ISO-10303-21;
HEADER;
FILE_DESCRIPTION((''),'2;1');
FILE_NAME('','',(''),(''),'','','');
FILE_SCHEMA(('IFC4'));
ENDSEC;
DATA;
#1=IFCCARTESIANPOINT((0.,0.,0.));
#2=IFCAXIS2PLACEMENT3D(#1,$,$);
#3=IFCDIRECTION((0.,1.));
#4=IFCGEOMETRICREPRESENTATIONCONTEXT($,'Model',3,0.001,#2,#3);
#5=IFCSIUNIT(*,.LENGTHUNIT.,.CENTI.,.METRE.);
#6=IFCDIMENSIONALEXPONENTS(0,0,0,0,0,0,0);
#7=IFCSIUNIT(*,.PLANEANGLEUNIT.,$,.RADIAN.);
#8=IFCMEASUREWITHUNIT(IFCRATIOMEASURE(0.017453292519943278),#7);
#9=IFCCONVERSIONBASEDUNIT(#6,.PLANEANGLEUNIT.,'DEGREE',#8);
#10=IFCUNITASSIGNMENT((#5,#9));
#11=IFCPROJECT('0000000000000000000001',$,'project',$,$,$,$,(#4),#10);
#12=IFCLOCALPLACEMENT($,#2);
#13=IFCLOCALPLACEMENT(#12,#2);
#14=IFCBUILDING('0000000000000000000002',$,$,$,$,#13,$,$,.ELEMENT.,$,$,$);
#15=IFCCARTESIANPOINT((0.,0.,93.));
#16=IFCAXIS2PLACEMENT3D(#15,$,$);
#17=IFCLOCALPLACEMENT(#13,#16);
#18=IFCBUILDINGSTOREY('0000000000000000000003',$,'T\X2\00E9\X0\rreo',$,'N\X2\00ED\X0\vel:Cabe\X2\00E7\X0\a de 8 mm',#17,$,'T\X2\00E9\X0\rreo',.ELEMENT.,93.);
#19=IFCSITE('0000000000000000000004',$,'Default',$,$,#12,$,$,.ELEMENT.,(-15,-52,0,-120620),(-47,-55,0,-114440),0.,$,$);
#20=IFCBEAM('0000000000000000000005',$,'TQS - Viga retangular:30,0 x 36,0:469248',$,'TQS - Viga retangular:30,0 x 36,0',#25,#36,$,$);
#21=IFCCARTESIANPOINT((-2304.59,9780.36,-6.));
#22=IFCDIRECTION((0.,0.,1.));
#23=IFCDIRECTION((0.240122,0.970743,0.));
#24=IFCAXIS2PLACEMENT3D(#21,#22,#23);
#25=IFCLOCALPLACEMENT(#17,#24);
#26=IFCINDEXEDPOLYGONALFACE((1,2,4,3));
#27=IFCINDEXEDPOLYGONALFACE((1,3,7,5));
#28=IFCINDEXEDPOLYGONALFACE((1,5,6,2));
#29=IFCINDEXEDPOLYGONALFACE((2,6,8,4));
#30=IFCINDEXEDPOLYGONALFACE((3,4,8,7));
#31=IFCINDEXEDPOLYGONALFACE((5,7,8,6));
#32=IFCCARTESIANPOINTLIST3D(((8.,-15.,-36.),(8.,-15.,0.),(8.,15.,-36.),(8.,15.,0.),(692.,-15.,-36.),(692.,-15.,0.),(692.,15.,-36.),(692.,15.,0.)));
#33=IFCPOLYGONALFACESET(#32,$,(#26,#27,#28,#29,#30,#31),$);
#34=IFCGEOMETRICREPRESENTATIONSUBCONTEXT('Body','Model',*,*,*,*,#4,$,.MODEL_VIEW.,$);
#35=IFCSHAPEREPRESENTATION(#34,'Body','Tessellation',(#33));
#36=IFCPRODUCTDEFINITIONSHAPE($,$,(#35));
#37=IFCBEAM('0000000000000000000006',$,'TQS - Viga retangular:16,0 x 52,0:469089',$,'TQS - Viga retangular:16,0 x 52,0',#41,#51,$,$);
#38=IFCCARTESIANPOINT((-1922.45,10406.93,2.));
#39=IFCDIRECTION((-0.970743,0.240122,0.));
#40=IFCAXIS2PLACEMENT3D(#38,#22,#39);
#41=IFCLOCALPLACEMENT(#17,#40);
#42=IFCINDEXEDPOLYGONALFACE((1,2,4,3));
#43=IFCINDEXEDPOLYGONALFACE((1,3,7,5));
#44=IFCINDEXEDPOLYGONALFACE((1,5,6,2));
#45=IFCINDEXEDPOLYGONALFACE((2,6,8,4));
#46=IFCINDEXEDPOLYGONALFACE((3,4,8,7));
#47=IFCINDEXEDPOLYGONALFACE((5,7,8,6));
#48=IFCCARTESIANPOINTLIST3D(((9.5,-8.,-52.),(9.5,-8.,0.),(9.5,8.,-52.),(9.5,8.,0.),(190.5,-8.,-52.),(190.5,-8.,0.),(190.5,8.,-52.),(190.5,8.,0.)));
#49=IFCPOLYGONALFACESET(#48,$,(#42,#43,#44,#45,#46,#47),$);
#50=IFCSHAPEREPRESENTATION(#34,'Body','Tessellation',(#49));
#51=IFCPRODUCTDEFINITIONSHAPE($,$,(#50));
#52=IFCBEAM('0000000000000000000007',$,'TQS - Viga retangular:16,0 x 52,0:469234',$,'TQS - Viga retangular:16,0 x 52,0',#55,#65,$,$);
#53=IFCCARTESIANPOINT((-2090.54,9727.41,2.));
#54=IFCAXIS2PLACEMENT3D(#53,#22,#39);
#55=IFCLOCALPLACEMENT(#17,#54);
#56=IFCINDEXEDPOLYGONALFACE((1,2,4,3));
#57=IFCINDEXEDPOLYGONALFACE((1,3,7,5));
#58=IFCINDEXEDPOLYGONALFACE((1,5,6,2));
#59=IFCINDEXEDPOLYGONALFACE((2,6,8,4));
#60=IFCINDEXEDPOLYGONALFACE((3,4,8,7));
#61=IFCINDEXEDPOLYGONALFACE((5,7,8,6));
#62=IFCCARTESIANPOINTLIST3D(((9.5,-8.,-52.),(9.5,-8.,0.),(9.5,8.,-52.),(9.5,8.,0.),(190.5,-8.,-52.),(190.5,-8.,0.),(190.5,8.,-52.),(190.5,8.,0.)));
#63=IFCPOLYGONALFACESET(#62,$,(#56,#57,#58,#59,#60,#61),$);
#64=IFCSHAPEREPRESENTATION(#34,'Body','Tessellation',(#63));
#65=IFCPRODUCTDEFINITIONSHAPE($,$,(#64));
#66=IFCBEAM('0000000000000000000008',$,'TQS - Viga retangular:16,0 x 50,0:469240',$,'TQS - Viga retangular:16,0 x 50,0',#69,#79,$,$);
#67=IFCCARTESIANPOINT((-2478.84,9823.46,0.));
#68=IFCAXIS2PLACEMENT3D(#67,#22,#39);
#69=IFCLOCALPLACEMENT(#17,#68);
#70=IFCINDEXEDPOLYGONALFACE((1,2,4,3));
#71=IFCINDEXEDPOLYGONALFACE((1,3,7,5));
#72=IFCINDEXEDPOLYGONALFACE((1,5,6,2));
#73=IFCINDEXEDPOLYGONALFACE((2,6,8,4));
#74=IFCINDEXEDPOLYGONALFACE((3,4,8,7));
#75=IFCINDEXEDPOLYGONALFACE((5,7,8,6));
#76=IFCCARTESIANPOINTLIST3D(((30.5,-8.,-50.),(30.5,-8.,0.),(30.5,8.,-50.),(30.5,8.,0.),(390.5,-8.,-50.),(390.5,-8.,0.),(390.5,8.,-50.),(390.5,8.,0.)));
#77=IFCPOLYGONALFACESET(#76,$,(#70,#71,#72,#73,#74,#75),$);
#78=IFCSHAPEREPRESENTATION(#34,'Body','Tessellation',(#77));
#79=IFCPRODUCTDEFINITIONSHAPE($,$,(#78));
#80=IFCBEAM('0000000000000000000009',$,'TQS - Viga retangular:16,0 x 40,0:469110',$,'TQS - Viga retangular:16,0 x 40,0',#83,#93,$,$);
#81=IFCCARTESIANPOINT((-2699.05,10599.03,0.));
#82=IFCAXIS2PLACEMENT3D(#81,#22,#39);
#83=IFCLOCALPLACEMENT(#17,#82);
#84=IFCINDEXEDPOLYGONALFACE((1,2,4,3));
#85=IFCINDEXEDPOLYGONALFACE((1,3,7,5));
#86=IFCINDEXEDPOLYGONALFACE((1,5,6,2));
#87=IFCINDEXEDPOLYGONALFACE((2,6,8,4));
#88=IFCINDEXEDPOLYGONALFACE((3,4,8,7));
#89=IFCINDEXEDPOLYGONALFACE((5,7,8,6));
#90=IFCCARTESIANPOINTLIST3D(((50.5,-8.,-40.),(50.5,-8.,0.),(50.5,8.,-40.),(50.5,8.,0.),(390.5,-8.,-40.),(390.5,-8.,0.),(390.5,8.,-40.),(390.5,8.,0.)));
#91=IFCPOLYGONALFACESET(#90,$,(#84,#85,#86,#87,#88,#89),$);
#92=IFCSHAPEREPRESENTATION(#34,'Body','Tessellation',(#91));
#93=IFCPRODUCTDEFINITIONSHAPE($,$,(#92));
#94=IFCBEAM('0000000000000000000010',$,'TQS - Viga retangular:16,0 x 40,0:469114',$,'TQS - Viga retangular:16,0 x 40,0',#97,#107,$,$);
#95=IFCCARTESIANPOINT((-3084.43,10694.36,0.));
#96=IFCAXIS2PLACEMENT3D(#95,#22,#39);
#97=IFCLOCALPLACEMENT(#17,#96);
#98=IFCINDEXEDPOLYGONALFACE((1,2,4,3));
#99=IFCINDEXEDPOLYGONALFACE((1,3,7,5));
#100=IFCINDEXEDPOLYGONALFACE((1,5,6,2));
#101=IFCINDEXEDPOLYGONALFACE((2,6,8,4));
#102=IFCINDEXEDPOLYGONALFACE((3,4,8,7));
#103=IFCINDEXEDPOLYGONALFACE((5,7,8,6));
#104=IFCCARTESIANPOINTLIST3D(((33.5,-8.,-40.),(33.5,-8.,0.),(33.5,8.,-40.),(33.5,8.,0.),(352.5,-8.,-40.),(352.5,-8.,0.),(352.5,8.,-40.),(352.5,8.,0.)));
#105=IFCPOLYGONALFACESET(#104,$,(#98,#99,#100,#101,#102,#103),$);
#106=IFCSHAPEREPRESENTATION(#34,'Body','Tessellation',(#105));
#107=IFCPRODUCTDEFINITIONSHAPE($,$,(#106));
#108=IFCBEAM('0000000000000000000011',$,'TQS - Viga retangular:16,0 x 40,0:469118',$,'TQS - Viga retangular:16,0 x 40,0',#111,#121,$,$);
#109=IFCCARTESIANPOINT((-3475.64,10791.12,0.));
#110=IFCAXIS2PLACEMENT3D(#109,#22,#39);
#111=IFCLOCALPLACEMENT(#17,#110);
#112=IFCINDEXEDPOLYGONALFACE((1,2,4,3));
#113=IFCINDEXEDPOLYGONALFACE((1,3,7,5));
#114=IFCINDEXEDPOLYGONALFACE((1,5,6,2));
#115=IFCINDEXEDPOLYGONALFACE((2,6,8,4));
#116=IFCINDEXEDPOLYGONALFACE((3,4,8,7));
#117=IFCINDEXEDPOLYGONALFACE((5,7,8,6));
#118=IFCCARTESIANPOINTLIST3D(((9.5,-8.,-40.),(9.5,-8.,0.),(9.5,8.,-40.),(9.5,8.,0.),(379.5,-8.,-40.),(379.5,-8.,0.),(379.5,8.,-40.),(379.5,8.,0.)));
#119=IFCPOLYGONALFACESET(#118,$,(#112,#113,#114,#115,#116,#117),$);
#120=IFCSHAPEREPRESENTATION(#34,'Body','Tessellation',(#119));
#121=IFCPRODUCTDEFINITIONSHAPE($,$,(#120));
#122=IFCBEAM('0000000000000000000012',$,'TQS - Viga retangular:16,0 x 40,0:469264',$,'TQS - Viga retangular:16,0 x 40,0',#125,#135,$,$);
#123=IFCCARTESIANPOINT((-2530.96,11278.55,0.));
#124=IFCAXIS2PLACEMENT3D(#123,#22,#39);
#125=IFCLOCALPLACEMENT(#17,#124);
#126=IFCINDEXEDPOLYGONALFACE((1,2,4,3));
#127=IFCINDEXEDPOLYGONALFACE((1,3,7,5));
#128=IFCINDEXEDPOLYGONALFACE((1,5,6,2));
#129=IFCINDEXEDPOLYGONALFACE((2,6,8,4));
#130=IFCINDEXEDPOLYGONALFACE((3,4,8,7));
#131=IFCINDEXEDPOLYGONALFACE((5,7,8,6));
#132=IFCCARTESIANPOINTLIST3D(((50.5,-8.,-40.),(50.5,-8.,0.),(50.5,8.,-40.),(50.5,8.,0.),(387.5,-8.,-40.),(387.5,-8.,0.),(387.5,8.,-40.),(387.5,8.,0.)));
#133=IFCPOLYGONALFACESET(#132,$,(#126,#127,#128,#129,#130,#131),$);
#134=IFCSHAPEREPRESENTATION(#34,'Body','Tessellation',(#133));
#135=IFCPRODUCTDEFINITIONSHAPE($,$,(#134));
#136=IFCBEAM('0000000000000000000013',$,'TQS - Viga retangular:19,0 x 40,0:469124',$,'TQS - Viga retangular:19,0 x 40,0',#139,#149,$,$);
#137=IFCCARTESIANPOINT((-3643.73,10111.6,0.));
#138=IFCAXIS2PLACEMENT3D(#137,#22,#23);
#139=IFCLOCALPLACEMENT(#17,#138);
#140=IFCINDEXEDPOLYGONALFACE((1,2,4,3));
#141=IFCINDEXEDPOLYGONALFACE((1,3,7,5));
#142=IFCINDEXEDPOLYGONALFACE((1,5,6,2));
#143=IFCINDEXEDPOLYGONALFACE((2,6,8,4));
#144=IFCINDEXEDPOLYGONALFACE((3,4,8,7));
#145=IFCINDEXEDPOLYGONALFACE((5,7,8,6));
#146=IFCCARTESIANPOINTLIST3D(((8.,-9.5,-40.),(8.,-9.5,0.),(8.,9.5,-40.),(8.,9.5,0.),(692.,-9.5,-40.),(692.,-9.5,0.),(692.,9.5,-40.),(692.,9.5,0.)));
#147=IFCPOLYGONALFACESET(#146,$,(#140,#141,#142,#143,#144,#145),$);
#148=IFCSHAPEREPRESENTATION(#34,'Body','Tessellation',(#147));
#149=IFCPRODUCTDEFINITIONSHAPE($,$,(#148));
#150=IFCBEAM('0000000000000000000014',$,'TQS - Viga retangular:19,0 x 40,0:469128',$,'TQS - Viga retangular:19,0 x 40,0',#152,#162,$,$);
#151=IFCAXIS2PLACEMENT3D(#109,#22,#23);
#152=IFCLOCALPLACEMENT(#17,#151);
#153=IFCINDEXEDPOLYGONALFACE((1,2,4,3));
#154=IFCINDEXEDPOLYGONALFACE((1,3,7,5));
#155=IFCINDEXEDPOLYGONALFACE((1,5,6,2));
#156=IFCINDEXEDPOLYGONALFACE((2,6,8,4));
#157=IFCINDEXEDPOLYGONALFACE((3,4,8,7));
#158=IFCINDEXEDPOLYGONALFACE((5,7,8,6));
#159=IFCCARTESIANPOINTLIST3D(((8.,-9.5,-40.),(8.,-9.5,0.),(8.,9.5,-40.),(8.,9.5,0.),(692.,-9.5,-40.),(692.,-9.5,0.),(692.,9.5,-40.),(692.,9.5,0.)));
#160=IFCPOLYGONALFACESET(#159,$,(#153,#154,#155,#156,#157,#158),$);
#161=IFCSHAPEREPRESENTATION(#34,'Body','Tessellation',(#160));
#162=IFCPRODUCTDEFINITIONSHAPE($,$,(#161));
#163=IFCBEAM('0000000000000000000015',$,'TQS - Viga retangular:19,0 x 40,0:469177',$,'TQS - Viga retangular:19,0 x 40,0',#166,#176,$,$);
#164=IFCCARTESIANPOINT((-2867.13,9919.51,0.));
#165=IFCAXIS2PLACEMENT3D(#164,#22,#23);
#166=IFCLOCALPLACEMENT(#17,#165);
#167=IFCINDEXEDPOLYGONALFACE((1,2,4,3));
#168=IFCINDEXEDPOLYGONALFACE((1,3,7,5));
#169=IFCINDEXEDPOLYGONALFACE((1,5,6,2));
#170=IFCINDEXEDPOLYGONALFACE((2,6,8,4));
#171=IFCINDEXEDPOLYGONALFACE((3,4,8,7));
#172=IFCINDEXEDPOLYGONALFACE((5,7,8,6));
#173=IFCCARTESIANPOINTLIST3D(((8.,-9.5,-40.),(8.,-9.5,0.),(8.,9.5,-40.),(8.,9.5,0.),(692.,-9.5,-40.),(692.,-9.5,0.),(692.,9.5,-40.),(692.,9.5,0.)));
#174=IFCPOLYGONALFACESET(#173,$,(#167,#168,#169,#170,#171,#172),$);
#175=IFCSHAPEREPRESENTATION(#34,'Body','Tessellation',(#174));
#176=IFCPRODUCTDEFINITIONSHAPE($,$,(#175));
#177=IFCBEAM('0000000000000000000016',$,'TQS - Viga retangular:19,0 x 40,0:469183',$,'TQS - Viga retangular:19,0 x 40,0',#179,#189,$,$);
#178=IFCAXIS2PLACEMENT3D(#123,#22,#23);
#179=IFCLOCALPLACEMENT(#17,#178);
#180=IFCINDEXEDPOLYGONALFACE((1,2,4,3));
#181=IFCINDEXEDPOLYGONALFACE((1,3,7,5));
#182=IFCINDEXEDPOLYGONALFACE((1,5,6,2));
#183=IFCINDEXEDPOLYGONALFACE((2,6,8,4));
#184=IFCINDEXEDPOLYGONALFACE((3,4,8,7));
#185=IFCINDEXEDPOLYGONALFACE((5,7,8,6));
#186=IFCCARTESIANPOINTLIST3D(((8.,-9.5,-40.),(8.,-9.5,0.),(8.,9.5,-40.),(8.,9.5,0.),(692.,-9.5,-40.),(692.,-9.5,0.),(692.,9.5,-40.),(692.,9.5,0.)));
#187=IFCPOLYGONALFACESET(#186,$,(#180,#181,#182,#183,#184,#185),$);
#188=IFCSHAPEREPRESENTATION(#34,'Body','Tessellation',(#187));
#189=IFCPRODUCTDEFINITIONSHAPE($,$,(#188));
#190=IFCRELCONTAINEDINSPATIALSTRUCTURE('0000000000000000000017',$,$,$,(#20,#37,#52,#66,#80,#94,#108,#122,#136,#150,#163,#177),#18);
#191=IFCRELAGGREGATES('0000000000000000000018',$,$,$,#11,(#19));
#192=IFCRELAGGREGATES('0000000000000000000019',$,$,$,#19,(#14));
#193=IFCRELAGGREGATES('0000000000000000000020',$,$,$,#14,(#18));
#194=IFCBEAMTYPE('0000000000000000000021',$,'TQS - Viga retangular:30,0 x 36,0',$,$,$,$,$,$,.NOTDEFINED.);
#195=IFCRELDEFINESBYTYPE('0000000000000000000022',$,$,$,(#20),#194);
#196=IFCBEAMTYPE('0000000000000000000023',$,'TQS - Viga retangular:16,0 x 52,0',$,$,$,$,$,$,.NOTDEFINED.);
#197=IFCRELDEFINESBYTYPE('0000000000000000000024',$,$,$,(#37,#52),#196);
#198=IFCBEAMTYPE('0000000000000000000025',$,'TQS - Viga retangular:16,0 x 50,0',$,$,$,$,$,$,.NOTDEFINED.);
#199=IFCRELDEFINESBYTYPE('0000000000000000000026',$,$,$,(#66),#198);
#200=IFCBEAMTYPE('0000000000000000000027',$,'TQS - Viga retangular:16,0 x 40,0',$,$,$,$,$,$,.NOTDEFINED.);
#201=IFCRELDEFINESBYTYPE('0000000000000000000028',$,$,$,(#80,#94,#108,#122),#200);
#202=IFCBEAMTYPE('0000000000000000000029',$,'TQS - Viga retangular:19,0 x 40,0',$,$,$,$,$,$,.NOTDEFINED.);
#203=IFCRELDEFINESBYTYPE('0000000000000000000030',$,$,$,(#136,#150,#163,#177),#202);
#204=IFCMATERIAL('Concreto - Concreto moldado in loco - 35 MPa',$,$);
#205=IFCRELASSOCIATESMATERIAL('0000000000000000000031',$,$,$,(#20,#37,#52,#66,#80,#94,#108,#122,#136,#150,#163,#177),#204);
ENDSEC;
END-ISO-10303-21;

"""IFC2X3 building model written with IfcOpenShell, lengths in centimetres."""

from ifc_helpers import new_model, entity, si_unit, converted_unit, direction, frame, frame_2d, origin, place, context, subcontext, project, spatial, rectangle, extrude, material, type_object, element, save


model = new_model("IFC2X3")

# Units and contexts
model_context = context("Model", 3, precision=0.001, world=origin(), true_north=direction((0.0, 1.0)))
body_context = subcontext(model_context, "Body", "Model", "MODEL_VIEW")
ifc_project = project(units=[si_unit("LENGTHUNIT", "METRE", prefix="CENTI"), converted_unit("PLANEANGLEUNIT", "DEGREE", entity("IfcRatioMeasure", 0.017453292519943278), si_unit("PLANEANGLEUNIT", "RADIAN"), dimensions=[0, 0, 0, 0, 0, 0, 0])], contexts=[model_context])

# Site, building, storey
site_placement = place(None, origin())
site = spatial("IfcSite", under=ifc_project, at=site_placement, Name="Default", CompositionType="ELEMENT", RefLatitude=(-15, -52, 0, -120620), RefLongitude=(-47, -55, 0, -114440), RefElevation=0.0)
building_placement = place(site_placement, origin())
building = spatial("IfcBuilding", under=site, at=building_placement, CompositionType="ELEMENT")
storey_placement = place(building_placement, frame((0.0, 0.0, 93.0)))
storey = spatial("IfcBuildingStorey", under=building, at=storey_placement, Name="Térreo", ObjectType="Nível:Cabeça de 8 mm", LongName="Térreo", CompositionType="ELEMENT", Elevation=93.0)

# Beams
ifc_material_1 = material(Name="Concreto - Concreto moldado in loco - 35 MPa")
beam_type_1 = type_object("IfcBeamType", Name="TQS - Viga retangular:30,0 x 36,0", PredefinedType="NOTDEFINED")
beam_1_placement = place(storey_placement, frame((-2304.59, 9780.36, -6.0), z_axis=(0.0, 0.0, 1.0), x_axis=(0.240122, 0.970743, 0.0)))
element("IfcBeam", 1, at=beam_1_placement, inside=storey, type_object=beam_type_1, material=ifc_material_1, Name="TQS - Viga retangular:30,0 x 36,0:469248", ObjectType="TQS - Viga retangular:30,0 x 36,0", context=body_context, shape_type="SweptSolid", body=[
    extrude(rectangle(XDim=36.0, YDim=30.0, at=frame_2d((0.0, 0.0), x_axis=(1.0, 0.0))), frame((8.0, 0.0, -18.0), z_axis=(1.0, 0.0, 0.0), x_axis=(0.0, 0.0, -1.0)), (0.0, 0.0, 1.0), 684.0),
])
beam_type_2 = type_object("IfcBeamType", Name="TQS - Viga retangular:16,0 x 52,0", PredefinedType="NOTDEFINED")
beam_2_placement = place(storey_placement, frame((-1922.45, 10406.93, 2.0), z_axis=(0.0, 0.0, 1.0), x_axis=(-0.970743, 0.240122, 0.0)))
element("IfcBeam", 2, at=beam_2_placement, inside=storey, type_object=beam_type_2, material=ifc_material_1, Name="TQS - Viga retangular:16,0 x 52,0:469089", ObjectType="TQS - Viga retangular:16,0 x 52,0", context=body_context, shape_type="SweptSolid", body=[
    extrude(rectangle(XDim=52.0, YDim=16.0, at=frame_2d((0.0, 0.0), x_axis=(1.0, 0.0))), frame((9.5, 0.0, -26.0), z_axis=(1.0, 0.0, 0.0), x_axis=(0.0, 0.0, -1.0)), (0.0, 0.0, 1.0), 181.0),
])
beam_3_placement = place(storey_placement, frame((-2090.54, 9727.41, 2.0), z_axis=(0.0, 0.0, 1.0), x_axis=(-0.970743, 0.240122, 0.0)))
element("IfcBeam", 3, at=beam_3_placement, inside=storey, type_object=beam_type_2, material=ifc_material_1, Name="TQS - Viga retangular:16,0 x 52,0:469234", ObjectType="TQS - Viga retangular:16,0 x 52,0", context=body_context, shape_type="SweptSolid", body=[
    extrude(rectangle(XDim=52.0, YDim=16.0, at=frame_2d((0.0, 0.0), x_axis=(1.0, 0.0))), frame((9.5, 0.0, -26.0), z_axis=(1.0, 0.0, 0.0), x_axis=(0.0, 0.0, -1.0)), (0.0, 0.0, 1.0), 181.0),
])
beam_type_3 = type_object("IfcBeamType", Name="TQS - Viga retangular:16,0 x 50,0", PredefinedType="NOTDEFINED")
beam_4_placement = place(storey_placement, frame((-2478.84, 9823.46, 0.0), z_axis=(0.0, 0.0, 1.0), x_axis=(-0.970743, 0.240122, 0.0)))
element("IfcBeam", 4, at=beam_4_placement, inside=storey, type_object=beam_type_3, material=ifc_material_1, Name="TQS - Viga retangular:16,0 x 50,0:469240", ObjectType="TQS - Viga retangular:16,0 x 50,0", context=body_context, shape_type="SweptSolid", body=[
    extrude(rectangle(XDim=50.0, YDim=16.0, at=frame_2d((0.0, 0.0), x_axis=(1.0, 0.0))), frame((30.5, 0.0, -25.0), z_axis=(1.0, 0.0, 0.0), x_axis=(0.0, 0.0, -1.0)), (0.0, 0.0, 1.0), 360.0),
])
beam_type_4 = type_object("IfcBeamType", Name="TQS - Viga retangular:16,0 x 40,0", PredefinedType="NOTDEFINED")
beam_5_placement = place(storey_placement, frame((-2699.05, 10599.03, 0.0), z_axis=(0.0, 0.0, 1.0), x_axis=(-0.970743, 0.240122, 0.0)))
element("IfcBeam", 5, at=beam_5_placement, inside=storey, type_object=beam_type_4, material=ifc_material_1, Name="TQS - Viga retangular:16,0 x 40,0:469110", ObjectType="TQS - Viga retangular:16,0 x 40,0", context=body_context, shape_type="SweptSolid", body=[
    extrude(rectangle(XDim=40.0, YDim=16.0, at=frame_2d((0.0, 0.0), x_axis=(1.0, 0.0))), frame((50.5, 0.0, -20.0), z_axis=(1.0, 0.0, 0.0), x_axis=(0.0, 0.0, -1.0)), (0.0, 0.0, 1.0), 340.0),
])
beam_6_placement = place(storey_placement, frame((-3084.43, 10694.36, 0.0), z_axis=(0.0, 0.0, 1.0), x_axis=(-0.970743, 0.240122, 0.0)))
element("IfcBeam", 6, at=beam_6_placement, inside=storey, type_object=beam_type_4, material=ifc_material_1, Name="TQS - Viga retangular:16,0 x 40,0:469114", ObjectType="TQS - Viga retangular:16,0 x 40,0", context=body_context, shape_type="SweptSolid", body=[
    extrude(rectangle(XDim=40.0, YDim=16.0, at=frame_2d((0.0, 0.0), x_axis=(1.0, 0.0))), frame((33.5, 0.0, -20.0), z_axis=(1.0, 0.0, 0.0), x_axis=(0.0, 0.0, -1.0)), (0.0, 0.0, 1.0), 319.0),
])
beam_7_placement = place(storey_placement, frame((-3475.64, 10791.12, 0.0), z_axis=(0.0, 0.0, 1.0), x_axis=(-0.970743, 0.240122, 0.0)))
element("IfcBeam", 7, at=beam_7_placement, inside=storey, type_object=beam_type_4, material=ifc_material_1, Name="TQS - Viga retangular:16,0 x 40,0:469118", ObjectType="TQS - Viga retangular:16,0 x 40,0", context=body_context, shape_type="SweptSolid", body=[
    extrude(rectangle(XDim=40.0, YDim=16.0, at=frame_2d((0.0, 0.0), x_axis=(1.0, 0.0))), frame((9.5, 0.0, -20.0), z_axis=(1.0, 0.0, 0.0), x_axis=(0.0, 0.0, -1.0)), (0.0, 0.0, 1.0), 370.0),
])
beam_8_placement = place(storey_placement, frame((-2530.96, 11278.55, 0.0), z_axis=(0.0, 0.0, 1.0), x_axis=(-0.970743, 0.240122, 0.0)))
element("IfcBeam", 8, at=beam_8_placement, inside=storey, type_object=beam_type_4, material=ifc_material_1, Name="TQS - Viga retangular:16,0 x 40,0:469264", ObjectType="TQS - Viga retangular:16,0 x 40,0", context=body_context, shape_type="SweptSolid", body=[
    extrude(rectangle(XDim=40.0, YDim=16.0, at=frame_2d((0.0, 0.0), x_axis=(1.0, 0.0))), frame((50.5, 0.0, -20.0), z_axis=(1.0, 0.0, 0.0), x_axis=(0.0, 0.0, -1.0)), (0.0, 0.0, 1.0), 337.0),
])
beam_type_5 = type_object("IfcBeamType", Name="TQS - Viga retangular:19,0 x 40,0", PredefinedType="NOTDEFINED")
beam_9_placement = place(storey_placement, frame((-3643.73, 10111.6, 0.0), z_axis=(0.0, 0.0, 1.0), x_axis=(0.240122, 0.970743, 0.0)))
element("IfcBeam", 9, at=beam_9_placement, inside=storey, type_object=beam_type_5, material=ifc_material_1, Name="TQS - Viga retangular:19,0 x 40,0:469124", ObjectType="TQS - Viga retangular:19,0 x 40,0", context=body_context, shape_type="SweptSolid", body=[
    extrude(rectangle(XDim=40.0, YDim=19.0, at=frame_2d((0.0, 0.0), x_axis=(1.0, 0.0))), frame((8.0, 0.0, -20.0), z_axis=(1.0, 0.0, 0.0), x_axis=(0.0, 0.0, -1.0)), (0.0, 0.0, 1.0), 684.0),
])
beam_10_placement = place(storey_placement, frame((-3475.64, 10791.12, 0.0), z_axis=(0.0, 0.0, 1.0), x_axis=(0.240122, 0.970743, 0.0)))
element("IfcBeam", 10, at=beam_10_placement, inside=storey, type_object=beam_type_5, material=ifc_material_1, Name="TQS - Viga retangular:19,0 x 40,0:469128", ObjectType="TQS - Viga retangular:19,0 x 40,0", context=body_context, shape_type="SweptSolid", body=[
    extrude(rectangle(XDim=40.0, YDim=19.0, at=frame_2d((0.0, 0.0), x_axis=(1.0, 0.0))), frame((8.0, 0.0, -20.0), z_axis=(1.0, 0.0, 0.0), x_axis=(0.0, 0.0, -1.0)), (0.0, 0.0, 1.0), 684.0),
])
beam_11_placement = place(storey_placement, frame((-2867.13, 9919.51, 0.0), z_axis=(0.0, 0.0, 1.0), x_axis=(0.240122, 0.970743, 0.0)))
element("IfcBeam", 11, at=beam_11_placement, inside=storey, type_object=beam_type_5, material=ifc_material_1, Name="TQS - Viga retangular:19,0 x 40,0:469177", ObjectType="TQS - Viga retangular:19,0 x 40,0", context=body_context, shape_type="SweptSolid", body=[
    extrude(rectangle(XDim=40.0, YDim=19.0, at=frame_2d((0.0, 0.0), x_axis=(1.0, 0.0))), frame((8.0, 0.0, -20.0), z_axis=(1.0, 0.0, 0.0), x_axis=(0.0, 0.0, -1.0)), (0.0, 0.0, 1.0), 684.0),
])
beam_12_placement = place(storey_placement, frame((-2530.96, 11278.55, 0.0), z_axis=(0.0, 0.0, 1.0), x_axis=(0.240122, 0.970743, 0.0)))
element("IfcBeam", 12, at=beam_12_placement, inside=storey, type_object=beam_type_5, material=ifc_material_1, Name="TQS - Viga retangular:19,0 x 40,0:469183", ObjectType="TQS - Viga retangular:19,0 x 40,0", context=body_context, shape_type="SweptSolid", body=[
    extrude(rectangle(XDim=40.0, YDim=19.0, at=frame_2d((0.0, 0.0), x_axis=(1.0, 0.0))), frame((8.0, 0.0, -20.0), z_axis=(1.0, 0.0, 0.0), x_axis=(0.0, 0.0, -1.0)), (0.0, 0.0, 1.0), 684.0),
])

save(model, "model.ifc")
